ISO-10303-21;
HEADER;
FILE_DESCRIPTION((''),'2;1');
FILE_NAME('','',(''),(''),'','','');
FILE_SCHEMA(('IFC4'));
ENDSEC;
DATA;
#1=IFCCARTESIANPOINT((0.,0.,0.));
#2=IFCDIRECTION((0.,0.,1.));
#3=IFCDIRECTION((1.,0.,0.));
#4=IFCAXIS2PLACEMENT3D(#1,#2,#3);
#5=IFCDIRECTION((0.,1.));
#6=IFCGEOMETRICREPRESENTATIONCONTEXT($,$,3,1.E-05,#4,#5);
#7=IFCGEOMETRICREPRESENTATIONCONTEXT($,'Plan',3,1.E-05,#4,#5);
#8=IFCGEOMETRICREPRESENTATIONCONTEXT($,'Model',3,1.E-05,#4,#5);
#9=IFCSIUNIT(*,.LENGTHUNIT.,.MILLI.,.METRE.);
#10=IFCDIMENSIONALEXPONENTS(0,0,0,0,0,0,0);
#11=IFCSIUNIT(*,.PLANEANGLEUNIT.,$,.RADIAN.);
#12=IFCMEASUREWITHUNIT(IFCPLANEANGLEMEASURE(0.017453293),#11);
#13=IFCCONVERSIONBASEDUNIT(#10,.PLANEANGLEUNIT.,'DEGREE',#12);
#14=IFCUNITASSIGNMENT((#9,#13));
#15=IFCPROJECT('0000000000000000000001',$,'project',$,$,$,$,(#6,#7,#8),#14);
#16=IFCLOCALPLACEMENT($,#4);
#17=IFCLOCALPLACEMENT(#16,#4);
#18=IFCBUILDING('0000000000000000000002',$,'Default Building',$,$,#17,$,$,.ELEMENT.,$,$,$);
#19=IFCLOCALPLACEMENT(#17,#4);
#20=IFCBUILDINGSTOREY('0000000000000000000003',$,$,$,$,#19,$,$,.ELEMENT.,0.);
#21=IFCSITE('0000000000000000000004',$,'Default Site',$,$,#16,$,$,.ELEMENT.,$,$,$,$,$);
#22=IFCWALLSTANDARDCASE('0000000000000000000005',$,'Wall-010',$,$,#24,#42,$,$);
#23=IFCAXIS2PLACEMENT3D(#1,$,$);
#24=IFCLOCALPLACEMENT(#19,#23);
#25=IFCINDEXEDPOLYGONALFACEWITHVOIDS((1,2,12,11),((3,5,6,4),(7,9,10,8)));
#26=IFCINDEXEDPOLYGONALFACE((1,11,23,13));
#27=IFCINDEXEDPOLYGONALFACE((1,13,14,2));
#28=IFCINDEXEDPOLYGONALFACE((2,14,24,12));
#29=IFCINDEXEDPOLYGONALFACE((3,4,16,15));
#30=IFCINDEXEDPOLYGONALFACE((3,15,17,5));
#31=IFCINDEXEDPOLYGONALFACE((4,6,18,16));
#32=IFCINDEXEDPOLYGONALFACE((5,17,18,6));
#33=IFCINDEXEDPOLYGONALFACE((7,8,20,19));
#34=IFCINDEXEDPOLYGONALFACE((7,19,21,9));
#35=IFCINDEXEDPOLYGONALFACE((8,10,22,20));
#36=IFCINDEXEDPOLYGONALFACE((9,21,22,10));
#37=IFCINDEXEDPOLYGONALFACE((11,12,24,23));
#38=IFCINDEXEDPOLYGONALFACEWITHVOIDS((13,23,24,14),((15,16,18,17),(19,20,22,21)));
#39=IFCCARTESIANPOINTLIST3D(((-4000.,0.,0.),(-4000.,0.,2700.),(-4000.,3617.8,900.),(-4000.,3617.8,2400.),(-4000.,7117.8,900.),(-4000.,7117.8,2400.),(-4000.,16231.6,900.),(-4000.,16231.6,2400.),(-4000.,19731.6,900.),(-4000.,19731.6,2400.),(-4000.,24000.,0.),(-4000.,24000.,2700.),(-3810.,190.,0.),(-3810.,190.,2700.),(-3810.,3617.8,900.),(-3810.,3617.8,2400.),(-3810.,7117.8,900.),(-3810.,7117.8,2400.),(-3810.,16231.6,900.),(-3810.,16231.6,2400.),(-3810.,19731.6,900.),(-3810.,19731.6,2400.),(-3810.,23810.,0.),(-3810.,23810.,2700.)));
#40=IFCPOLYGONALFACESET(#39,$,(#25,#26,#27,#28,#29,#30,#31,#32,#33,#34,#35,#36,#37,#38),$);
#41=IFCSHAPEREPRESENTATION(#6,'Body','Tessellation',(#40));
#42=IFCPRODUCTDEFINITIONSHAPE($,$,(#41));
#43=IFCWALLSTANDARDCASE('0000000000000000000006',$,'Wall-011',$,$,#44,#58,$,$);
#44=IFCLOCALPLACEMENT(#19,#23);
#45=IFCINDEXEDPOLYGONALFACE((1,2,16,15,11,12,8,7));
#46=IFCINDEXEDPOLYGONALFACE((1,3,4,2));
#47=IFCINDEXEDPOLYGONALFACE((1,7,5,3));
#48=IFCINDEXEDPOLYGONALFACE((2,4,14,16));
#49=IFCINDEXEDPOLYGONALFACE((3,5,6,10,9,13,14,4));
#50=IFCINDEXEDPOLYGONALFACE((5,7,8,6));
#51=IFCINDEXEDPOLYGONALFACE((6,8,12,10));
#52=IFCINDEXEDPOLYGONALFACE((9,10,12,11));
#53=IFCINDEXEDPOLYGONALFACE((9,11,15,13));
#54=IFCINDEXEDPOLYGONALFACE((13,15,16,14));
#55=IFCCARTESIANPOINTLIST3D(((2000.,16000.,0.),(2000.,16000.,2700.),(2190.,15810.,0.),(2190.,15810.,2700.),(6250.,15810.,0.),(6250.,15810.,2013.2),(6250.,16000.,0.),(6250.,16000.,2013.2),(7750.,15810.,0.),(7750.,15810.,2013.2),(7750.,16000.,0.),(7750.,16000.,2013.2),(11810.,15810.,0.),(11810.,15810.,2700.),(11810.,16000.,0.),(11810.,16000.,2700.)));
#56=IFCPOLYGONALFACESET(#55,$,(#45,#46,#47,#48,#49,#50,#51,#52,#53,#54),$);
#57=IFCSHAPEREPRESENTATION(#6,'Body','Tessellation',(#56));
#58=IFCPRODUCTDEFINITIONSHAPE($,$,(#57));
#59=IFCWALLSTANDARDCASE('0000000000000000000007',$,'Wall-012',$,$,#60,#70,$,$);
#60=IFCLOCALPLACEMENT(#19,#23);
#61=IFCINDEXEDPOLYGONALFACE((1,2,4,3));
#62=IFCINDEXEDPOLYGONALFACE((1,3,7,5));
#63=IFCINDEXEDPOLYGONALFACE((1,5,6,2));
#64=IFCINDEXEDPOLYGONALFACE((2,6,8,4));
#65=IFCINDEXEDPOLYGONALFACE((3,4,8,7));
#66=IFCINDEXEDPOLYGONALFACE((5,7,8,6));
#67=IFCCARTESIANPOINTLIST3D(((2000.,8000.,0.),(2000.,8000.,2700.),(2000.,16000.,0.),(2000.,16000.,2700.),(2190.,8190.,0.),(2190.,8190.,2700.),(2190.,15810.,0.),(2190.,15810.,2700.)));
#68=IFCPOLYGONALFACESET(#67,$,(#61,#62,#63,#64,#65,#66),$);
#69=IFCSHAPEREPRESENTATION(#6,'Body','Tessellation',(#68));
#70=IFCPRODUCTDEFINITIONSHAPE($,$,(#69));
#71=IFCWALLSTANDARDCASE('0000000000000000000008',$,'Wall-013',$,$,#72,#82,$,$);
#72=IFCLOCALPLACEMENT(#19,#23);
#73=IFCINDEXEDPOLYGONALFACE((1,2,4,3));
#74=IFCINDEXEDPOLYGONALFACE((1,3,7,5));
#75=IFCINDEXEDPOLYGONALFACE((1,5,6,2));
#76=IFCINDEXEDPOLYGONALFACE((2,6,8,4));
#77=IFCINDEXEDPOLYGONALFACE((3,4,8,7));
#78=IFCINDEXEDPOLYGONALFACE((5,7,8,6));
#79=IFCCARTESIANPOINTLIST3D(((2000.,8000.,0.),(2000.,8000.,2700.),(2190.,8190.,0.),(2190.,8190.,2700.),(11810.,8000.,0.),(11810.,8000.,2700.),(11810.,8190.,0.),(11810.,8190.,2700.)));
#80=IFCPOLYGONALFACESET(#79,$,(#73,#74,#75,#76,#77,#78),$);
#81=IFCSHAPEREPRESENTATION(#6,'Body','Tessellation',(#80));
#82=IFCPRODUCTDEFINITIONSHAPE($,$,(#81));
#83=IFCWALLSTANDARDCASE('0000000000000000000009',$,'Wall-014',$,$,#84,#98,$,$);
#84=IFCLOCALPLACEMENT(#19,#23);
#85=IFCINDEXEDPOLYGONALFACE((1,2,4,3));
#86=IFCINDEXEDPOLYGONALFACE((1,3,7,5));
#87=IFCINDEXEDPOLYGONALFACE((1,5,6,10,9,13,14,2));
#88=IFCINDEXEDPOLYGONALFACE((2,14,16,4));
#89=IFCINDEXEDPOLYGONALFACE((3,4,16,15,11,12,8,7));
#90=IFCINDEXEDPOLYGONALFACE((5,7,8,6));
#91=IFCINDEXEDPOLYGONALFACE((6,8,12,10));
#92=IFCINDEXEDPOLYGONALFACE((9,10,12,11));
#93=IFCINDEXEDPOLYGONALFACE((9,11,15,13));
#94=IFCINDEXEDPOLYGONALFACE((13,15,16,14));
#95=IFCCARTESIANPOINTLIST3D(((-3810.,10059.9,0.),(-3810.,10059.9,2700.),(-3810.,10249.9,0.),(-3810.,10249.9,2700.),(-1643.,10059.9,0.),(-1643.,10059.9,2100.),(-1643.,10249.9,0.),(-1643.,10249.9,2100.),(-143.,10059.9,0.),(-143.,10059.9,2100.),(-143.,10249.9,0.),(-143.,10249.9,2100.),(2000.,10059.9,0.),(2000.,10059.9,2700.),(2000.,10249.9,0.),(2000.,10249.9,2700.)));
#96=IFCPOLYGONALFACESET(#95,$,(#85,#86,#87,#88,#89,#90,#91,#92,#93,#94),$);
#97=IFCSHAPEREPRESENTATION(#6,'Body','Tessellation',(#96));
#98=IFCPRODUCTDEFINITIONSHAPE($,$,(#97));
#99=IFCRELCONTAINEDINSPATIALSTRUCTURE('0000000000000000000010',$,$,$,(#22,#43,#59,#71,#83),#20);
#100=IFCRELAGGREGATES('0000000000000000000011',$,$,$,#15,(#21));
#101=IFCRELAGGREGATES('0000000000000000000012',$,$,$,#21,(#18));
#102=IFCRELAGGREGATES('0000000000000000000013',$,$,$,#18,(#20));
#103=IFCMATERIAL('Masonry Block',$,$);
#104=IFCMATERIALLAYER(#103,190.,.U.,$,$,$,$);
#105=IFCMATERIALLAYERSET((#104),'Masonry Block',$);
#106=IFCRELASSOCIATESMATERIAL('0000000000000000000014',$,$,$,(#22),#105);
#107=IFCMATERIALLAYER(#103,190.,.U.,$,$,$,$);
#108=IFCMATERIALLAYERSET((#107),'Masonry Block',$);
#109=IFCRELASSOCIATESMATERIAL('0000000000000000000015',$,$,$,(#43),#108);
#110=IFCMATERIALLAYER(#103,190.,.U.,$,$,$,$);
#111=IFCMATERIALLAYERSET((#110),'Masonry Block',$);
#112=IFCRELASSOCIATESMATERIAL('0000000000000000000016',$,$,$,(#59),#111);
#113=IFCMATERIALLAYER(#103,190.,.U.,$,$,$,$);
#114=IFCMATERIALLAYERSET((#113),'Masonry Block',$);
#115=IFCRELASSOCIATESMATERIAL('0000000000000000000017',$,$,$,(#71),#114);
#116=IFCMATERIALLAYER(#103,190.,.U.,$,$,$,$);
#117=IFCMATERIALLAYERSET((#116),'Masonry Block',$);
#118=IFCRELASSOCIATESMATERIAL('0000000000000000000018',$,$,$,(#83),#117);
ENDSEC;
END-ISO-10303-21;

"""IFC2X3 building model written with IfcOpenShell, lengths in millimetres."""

from ifc_helpers import new_model, entity, si_unit, converted_unit, direction, frame, origin_with_axes, place, context, project, spatial, polyline, outline, extrude, material, layer, layer_set, layer_usage, element, save


model = new_model("IFC2X3")

# Units and contexts
context_of_model = context(None, 3, precision=1e-05, world=origin_with_axes(), true_north=direction((0.0, 1.0)))
plan_context = context("Plan", 3, precision=1e-05, world=origin_with_axes(), true_north=direction((0.0, 1.0)))
model_context = context("Model", 3, precision=1e-05, world=origin_with_axes(), true_north=direction((0.0, 1.0)))
ifc_project = project(units=[si_unit("LENGTHUNIT", "METRE", prefix="MILLI"), converted_unit("PLANEANGLEUNIT", "DEGREE", entity("IfcPlaneAngleMeasure", 0.017453293), si_unit("PLANEANGLEUNIT", "RADIAN"), dimensions=[0, 0, 0, 0, 0, 0, 0])], contexts=[context_of_model, plan_context, model_context])

# Site, building, storey
site_placement = place(None, origin_with_axes())
site = spatial("IfcSite", under=ifc_project, at=site_placement, Name="Default Site", CompositionType="ELEMENT")
building_placement = place(site_placement, origin_with_axes())
building = spatial("IfcBuilding", under=site, at=building_placement, Name="Default Building", CompositionType="ELEMENT")
storey_placement = place(building_placement, origin_with_axes())
storey = spatial("IfcBuildingStorey", under=building, at=storey_placement, CompositionType="ELEMENT", Elevation=0.0)

# Shared definitions
ifc_material_1 = material(Name="Masonry Block")

# Wall, openings
ifc_layer_1 = layer(ifc_material_1, 190.0, ventilated="UNKNOWN")
ifc_layer_set_1 = layer_set([ifc_layer_1], Name="Masonry Block")
ifc_layer_usage_1 = layer_usage(ifc_layer_set_1, "AXIS2", "POSITIVE", 0.0)
wall_1_placement = place(storey_placement, frame((-4000.0, 24000.0, 0.0), z_axis=(0.0, 0.0, 1.0), x_axis=(0.0, -1.0, 0.0)))
wall_1 = element("IfcWallStandardCase", 1, at=wall_1_placement, inside=storey, material=ifc_layer_usage_1, Name="Wall-010", context=context_of_model, shape_type="SweptSolid", body=[
    extrude(outline(polyline([(0.0, 0.0), (24000.0, 0.0), (23810.0, 190.0), (190.0, 190.0), (0.0, 0.0)])), origin_with_axes(), (0.0, 0.0, 1.0), 2700.0),
])
opening_1_placement = place(wall_1_placement, frame((18632.2, 0.0, 900.0), z_axis=(0.0, 0.0, 1.0), x_axis=(1.0, 0.0, 0.0)))
element("IfcOpeningElement", 2, at=opening_1_placement, cuts=wall_1, ObjectType="Opening", context=model_context, shape_type="SweptSolid", body=[
    extrude(outline(polyline([(-1750.0, 1500.0), (-1750.0, 0.0), (1750.0, 0.0), (1750.0, 1500.0), (-1750.0, 1500.0)])), frame((0.0, 0.0, 0.0), z_axis=(0.0, 1.0, 0.0), x_axis=(-1.0, 0.0, 0.0)), (0.0, 0.0, 1.0), 190.0),
])
opening_2_placement = place(wall_1_placement, frame((6018.4, 0.0, 900.0), z_axis=(0.0, 0.0, 1.0), x_axis=(1.0, 0.0, 0.0)))
element("IfcOpeningElement", 3, at=opening_2_placement, cuts=wall_1, ObjectType="Opening", context=model_context, shape_type="SweptSolid", body=[
    extrude(outline(polyline([(1750.0, 1500.0), (-1750.0, 1500.0), (-1750.0, 0.0), (1750.0, 0.0), (1750.0, 1500.0)])), frame((0.0, 0.0, 0.0), z_axis=(0.0, 1.0, 0.0), x_axis=(-1.0, 0.0, 0.0)), (0.0, 0.0, 1.0), 190.0),
])

# Wall, opening
ifc_layer_2 = layer(ifc_material_1, 190.0, ventilated="UNKNOWN")
ifc_layer_set_2 = layer_set([ifc_layer_2], Name="Masonry Block")
ifc_layer_usage_2 = layer_usage(ifc_layer_set_2, "AXIS2", "POSITIVE", 0.0)
wall_2_placement = place(storey_placement, frame((12000.0, 16000.0, 0.0), z_axis=(0.0, 0.0, 1.0), x_axis=(-1.0, 0.0, 0.0)))
wall_2 = element("IfcWallStandardCase", 4, at=wall_2_placement, inside=storey, material=ifc_layer_usage_2, Name="Wall-011", context=context_of_model, shape_type="SweptSolid", body=[
    extrude(outline(polyline([(190.0, 0.0), (10000.0, 0.0), (9810.0, 190.0), (190.0, 190.0), (190.0, 0.0)])), origin_with_axes(), (0.0, 0.0, 1.0), 2700.0),
])
opening_3_placement = place(wall_2_placement, frame((5000.0, 0.0, 0.0), z_axis=(0.0, 0.0, 1.0), x_axis=(1.0, 0.0, 0.0)))
element("IfcOpeningElement", 5, at=opening_3_placement, cuts=wall_2, ObjectType="Opening", context=model_context, shape_type="SweptSolid", body=[
    extrude(outline(polyline([(750.0, 2013.2), (-750.0, 2013.2), (-750.0, 0.0), (750.0, 0.0), (750.0, 2013.2)])), frame((0.0, 0.0, 0.0), z_axis=(0.0, 1.0, 0.0), x_axis=(-1.0, 0.0, 0.0)), (0.0, 0.0, 1.0), 190.0),
])

# Walls
ifc_layer_3 = layer(ifc_material_1, 190.0, ventilated="UNKNOWN")
ifc_layer_set_3 = layer_set([ifc_layer_3], Name="Masonry Block")
ifc_layer_usage_3 = layer_usage(ifc_layer_set_3, "AXIS2", "POSITIVE", 0.0)
wall_3_placement = place(storey_placement, frame((2000.0, 16000.0, 0.0), z_axis=(0.0, 0.0, 1.0), x_axis=(0.0, -1.0, 0.0)))
element("IfcWallStandardCase", 6, at=wall_3_placement, inside=storey, material=ifc_layer_usage_3, Name="Wall-012", context=context_of_model, shape_type="SweptSolid", body=[
    extrude(outline(polyline([(0.0, 0.0), (8000.0, 0.0), (7810.0, 190.0), (190.0, 190.0), (0.0, 0.0)])), origin_with_axes(), (0.0, 0.0, 1.0), 2700.0),
])
ifc_layer_4 = layer(ifc_material_1, 190.0, ventilated="UNKNOWN")
ifc_layer_set_4 = layer_set([ifc_layer_4], Name="Masonry Block")
ifc_layer_usage_4 = layer_usage(ifc_layer_set_4, "AXIS2", "POSITIVE", 0.0)
wall_4_placement = place(storey_placement, frame((2000.0, 8000.0, 0.0), z_axis=(0.0, 0.0, 1.0), x_axis=(1.0, 0.0, 0.0)))
element("IfcWallStandardCase", 7, at=wall_4_placement, inside=storey, material=ifc_layer_usage_4, Name="Wall-013", context=context_of_model, shape_type="SweptSolid", body=[
    extrude(outline(polyline([(0.0, 0.0), (9810.0, 0.0), (9810.0, 190.0), (190.0, 190.0), (0.0, 0.0)])), origin_with_axes(), (0.0, 0.0, 1.0), 2700.0),
])

# Wall, opening
ifc_layer_5 = layer(ifc_material_1, 190.0, ventilated="UNKNOWN")
ifc_layer_set_5 = layer_set([ifc_layer_5], Name="Masonry Block")
ifc_layer_usage_5 = layer_usage(ifc_layer_set_5, "AXIS2", "POSITIVE", 0.0)
wall_5_placement = place(storey_placement, frame((-4000.0, 10059.9, 0.0), z_axis=(0.0, 0.0, 1.0), x_axis=(1.0, 0.0, 0.0)))
wall_5 = element("IfcWallStandardCase", 8, at=wall_5_placement, inside=storey, material=ifc_layer_usage_5, Name="Wall-014", context=context_of_model, shape_type="SweptSolid", body=[
    extrude(outline(polyline([(190.0, 0.0), (6000.0, 0.0), (6000.0, 190.0), (190.0, 190.0), (190.0, 0.0)])), origin_with_axes(), (0.0, 0.0, 1.0), 2700.0),
])
opening_4_placement = place(wall_5_placement, frame((3107.0, 0.0, 0.0), z_axis=(0.0, 0.0, 1.0), x_axis=(1.0, 0.0, 0.0)))
element("IfcOpeningElement", 9, at=opening_4_placement, cuts=wall_5, ObjectType="Opening", context=model_context, shape_type="SweptSolid", body=[
    extrude(outline(polyline([(750.0, 2100.0), (-750.0, 2100.0), (-750.0, 0.0), (750.0, 0.0), (750.0, 2100.0)])), frame((0.0, 0.0, 0.0), z_axis=(0.0, 1.0, 0.0), x_axis=(-1.0, 0.0, 0.0)), (0.0, 0.0, 1.0), 190.0),
])

save(model, "model.ifc")
